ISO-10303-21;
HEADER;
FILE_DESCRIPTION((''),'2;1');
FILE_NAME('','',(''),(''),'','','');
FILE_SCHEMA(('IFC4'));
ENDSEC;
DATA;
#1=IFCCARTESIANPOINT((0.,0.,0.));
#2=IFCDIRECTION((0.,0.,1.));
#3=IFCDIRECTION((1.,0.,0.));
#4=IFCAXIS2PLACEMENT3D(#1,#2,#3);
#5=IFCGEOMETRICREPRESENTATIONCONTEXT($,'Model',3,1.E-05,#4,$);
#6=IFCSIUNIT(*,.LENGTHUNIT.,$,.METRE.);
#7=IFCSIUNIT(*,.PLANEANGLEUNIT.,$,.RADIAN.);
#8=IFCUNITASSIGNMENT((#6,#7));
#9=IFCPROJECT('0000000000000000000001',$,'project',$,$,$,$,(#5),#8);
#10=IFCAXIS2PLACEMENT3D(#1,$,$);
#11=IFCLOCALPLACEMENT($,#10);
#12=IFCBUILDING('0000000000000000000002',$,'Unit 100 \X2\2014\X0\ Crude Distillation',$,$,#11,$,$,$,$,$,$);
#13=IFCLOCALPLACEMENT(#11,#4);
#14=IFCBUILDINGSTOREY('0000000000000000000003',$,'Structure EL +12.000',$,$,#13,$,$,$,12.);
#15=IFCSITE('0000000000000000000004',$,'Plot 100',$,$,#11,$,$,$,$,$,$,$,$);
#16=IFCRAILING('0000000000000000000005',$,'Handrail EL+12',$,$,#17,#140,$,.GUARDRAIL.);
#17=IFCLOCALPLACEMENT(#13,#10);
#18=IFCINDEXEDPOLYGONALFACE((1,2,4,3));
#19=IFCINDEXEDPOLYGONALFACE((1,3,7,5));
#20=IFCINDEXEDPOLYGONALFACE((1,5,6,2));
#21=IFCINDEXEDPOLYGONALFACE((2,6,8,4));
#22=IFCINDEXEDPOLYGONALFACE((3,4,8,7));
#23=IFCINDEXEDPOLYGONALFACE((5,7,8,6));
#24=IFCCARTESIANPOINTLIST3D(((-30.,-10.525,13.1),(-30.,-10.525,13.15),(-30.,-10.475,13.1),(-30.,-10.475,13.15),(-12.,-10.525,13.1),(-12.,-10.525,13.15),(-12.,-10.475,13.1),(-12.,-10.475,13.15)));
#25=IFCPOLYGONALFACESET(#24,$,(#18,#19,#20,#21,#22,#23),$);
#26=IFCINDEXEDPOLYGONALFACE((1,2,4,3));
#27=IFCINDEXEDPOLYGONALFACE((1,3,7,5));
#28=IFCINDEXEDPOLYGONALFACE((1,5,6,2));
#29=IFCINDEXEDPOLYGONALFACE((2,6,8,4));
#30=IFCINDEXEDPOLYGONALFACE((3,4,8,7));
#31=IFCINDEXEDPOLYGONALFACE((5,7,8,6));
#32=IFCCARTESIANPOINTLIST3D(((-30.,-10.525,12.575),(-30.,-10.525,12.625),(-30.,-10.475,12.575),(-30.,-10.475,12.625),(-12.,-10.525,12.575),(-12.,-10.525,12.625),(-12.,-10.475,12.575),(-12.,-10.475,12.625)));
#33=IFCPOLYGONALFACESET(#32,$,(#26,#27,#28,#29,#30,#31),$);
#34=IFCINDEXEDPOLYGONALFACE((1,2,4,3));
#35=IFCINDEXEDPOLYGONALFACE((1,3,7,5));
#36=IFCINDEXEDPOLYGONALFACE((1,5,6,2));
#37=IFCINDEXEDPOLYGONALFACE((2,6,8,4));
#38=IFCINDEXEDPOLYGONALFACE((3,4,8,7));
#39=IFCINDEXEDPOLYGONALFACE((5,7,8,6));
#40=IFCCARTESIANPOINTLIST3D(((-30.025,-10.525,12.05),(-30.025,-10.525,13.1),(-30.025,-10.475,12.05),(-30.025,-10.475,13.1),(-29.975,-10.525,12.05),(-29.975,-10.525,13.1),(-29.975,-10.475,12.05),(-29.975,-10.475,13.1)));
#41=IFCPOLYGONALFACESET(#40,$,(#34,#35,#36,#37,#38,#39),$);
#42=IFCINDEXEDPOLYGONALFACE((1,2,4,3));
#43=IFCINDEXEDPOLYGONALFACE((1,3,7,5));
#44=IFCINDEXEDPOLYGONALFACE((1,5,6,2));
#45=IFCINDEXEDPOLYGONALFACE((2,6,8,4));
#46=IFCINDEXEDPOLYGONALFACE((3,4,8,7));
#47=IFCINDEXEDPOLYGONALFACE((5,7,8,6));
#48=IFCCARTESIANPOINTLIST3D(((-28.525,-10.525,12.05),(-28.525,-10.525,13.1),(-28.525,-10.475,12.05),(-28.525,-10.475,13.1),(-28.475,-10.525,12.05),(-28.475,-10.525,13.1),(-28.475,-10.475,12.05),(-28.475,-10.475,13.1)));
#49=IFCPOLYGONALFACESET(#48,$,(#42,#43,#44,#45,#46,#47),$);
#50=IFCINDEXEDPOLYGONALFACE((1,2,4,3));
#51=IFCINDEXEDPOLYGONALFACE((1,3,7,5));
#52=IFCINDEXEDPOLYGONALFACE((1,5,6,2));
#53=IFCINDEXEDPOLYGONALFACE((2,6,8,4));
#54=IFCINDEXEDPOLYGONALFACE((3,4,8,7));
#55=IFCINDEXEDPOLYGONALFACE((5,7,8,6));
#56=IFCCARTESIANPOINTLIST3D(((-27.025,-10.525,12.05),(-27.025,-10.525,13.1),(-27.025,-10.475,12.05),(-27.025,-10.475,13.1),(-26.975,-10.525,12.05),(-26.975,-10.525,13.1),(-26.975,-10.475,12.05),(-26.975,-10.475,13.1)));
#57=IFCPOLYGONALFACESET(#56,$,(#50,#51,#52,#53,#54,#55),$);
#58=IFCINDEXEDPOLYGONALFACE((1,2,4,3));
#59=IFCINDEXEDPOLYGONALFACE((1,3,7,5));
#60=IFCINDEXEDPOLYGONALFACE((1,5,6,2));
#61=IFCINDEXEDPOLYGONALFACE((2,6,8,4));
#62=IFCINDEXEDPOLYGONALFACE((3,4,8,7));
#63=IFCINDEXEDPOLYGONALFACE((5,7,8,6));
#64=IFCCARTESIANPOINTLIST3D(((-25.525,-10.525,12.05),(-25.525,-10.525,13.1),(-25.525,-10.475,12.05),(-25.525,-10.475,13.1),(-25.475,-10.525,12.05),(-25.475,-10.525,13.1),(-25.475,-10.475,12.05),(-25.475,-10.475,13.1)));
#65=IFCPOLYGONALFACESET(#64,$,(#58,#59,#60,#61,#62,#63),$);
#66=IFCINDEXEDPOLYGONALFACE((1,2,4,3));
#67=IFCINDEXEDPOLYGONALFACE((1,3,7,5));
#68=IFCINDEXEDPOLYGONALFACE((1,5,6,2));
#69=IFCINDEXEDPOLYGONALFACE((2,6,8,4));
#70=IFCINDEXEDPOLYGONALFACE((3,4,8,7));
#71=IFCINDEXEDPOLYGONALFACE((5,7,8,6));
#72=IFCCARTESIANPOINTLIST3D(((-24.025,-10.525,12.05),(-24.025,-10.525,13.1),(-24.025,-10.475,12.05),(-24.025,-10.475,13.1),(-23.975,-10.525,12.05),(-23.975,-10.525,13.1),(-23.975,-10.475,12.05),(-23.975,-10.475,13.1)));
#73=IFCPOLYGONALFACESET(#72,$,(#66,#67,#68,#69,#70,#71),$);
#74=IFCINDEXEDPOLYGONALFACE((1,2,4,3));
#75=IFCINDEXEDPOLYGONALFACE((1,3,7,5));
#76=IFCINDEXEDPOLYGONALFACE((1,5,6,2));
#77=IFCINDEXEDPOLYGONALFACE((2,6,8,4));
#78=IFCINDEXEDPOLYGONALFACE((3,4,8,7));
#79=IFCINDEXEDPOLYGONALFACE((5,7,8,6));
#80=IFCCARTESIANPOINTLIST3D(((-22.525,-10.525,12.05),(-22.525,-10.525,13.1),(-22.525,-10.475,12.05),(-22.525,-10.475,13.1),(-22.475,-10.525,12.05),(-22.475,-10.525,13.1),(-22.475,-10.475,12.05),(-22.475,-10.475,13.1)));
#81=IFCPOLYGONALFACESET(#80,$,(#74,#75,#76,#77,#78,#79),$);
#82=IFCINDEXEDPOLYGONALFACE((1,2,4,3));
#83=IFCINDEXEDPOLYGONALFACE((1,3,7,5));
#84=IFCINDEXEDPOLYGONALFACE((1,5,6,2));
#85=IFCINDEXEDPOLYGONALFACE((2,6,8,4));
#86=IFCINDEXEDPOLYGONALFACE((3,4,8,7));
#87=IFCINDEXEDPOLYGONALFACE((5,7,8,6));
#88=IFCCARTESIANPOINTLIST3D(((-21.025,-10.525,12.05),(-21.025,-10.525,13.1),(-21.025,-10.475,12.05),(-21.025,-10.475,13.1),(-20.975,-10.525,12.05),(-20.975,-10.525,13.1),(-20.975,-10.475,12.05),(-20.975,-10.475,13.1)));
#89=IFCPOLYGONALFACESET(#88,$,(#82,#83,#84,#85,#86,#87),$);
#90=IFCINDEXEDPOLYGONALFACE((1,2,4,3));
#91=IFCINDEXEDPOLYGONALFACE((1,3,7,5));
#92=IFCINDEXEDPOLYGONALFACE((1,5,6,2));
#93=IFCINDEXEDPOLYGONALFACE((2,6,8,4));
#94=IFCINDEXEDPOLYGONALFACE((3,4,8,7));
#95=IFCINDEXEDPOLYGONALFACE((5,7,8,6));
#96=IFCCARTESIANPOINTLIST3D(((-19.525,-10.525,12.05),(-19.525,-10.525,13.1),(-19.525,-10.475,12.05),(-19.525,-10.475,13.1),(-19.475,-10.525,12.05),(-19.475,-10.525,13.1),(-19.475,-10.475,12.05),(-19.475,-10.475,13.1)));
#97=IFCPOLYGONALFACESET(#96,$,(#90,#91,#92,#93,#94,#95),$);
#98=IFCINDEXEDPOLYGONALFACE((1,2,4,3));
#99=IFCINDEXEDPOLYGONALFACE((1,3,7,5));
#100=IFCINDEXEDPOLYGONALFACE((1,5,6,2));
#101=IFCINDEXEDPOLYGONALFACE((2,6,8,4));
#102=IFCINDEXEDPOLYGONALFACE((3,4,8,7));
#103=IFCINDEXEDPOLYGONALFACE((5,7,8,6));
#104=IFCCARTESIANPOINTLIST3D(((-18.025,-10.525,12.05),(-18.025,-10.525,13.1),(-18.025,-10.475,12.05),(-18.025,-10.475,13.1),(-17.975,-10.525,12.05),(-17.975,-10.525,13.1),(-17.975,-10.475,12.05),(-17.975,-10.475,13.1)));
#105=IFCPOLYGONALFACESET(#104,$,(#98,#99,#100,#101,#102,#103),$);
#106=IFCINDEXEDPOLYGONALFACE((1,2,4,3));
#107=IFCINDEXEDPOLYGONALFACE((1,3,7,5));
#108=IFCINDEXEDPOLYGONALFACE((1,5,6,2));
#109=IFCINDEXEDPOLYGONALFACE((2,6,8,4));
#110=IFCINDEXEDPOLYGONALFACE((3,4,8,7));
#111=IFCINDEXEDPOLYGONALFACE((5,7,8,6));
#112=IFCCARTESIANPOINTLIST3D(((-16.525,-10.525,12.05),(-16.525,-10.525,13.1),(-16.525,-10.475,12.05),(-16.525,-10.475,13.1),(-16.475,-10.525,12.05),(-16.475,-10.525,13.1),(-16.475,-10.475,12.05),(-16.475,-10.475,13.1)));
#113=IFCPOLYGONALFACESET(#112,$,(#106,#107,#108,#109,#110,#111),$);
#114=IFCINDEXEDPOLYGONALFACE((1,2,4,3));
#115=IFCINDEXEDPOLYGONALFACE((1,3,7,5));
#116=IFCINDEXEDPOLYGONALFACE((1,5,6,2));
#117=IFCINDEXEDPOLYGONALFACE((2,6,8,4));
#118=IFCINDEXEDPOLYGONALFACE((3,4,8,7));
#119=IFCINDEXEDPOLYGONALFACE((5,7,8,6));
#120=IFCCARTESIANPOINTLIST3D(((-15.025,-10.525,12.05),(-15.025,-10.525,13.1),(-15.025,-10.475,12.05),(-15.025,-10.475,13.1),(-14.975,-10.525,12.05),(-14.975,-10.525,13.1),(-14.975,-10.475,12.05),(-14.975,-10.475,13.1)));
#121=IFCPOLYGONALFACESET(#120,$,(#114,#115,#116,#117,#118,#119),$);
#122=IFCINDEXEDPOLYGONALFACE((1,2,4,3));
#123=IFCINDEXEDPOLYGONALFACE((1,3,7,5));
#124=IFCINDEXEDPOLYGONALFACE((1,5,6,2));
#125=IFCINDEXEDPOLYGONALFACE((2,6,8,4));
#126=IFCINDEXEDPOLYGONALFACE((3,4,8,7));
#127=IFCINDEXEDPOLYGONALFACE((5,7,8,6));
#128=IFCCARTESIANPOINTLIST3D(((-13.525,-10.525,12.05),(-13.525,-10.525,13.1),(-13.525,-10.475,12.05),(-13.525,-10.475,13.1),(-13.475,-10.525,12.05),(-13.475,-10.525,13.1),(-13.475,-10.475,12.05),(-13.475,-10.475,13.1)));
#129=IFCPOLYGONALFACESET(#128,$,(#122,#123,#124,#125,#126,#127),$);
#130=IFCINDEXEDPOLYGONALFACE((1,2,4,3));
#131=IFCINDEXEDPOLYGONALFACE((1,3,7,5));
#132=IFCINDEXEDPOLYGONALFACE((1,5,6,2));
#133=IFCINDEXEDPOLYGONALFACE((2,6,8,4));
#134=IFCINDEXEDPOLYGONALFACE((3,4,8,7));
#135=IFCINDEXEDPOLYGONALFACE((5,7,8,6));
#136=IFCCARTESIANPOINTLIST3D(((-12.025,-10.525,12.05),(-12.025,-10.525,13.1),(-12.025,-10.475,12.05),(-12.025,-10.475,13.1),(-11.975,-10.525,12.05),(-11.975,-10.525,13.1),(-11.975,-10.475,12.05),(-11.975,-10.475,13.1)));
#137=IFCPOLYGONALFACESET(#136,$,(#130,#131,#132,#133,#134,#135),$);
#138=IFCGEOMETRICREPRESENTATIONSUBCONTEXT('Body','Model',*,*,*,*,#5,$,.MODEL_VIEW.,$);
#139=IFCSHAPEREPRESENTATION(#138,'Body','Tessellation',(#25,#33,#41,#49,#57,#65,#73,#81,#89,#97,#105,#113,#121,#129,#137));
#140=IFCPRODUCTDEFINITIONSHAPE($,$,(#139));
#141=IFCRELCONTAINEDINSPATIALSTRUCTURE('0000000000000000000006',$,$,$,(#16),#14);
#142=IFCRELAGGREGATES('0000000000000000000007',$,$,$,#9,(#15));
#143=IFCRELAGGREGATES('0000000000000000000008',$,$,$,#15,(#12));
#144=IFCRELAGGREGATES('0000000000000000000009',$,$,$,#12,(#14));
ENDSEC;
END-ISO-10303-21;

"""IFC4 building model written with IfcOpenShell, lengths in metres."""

from ifc_helpers import new_model, si_unit, frame, origin, origin_with_axes, origin_2d, place, context, subcontext, project, spatial, rectangle, extrude, element, save


model = new_model("IFC4")

# Units and contexts
model_context = context("Model", 3, precision=1e-05, world=origin_with_axes())
body_context = subcontext(model_context, "Body", "Model", "MODEL_VIEW")
ifc_project = project(units=[si_unit("LENGTHUNIT", "METRE"), si_unit("PLANEANGLEUNIT", "RADIAN")], contexts=[model_context])

# Site, building, storey
placement = place(None, origin())
site = spatial("IfcSite", under=ifc_project, at=placement, Name="Plot 100")
building = spatial("IfcBuilding", under=site, at=placement, Name="Unit 100 — Crude Distillation")
storey_placement = place(placement, origin_with_axes())
storey = spatial("IfcBuildingStorey", under=building, at=storey_placement, Name="Structure EL +12.000", Elevation=12.0)

# Railing
railing_1_placement = place(storey_placement, origin_with_axes())
element("IfcRailing", 1, at=railing_1_placement, inside=storey, Name="Handrail EL+12", PredefinedType="GUARDRAIL", context=body_context, shape_type="SweptSolid", body=[
    extrude(rectangle(XDim=0.05, YDim=0.05, at=origin_2d()), frame((-30.0, -10.5, 13.125), z_axis=(1.0, 0.0, 0.0), x_axis=(0.0, 1.0, 0.0)), (0.0, 0.0, 1.0), 18.0),
    extrude(rectangle(XDim=0.05, YDim=0.05, at=origin_2d()), frame((-30.0, -10.5, 12.6), z_axis=(1.0, 0.0, 0.0), x_axis=(0.0, 1.0, 0.0)), (0.0, 0.0, 1.0), 18.0),
    extrude(rectangle(XDim=0.05, YDim=0.05, at=origin_2d()), frame((-30.0, -10.5, 12.05), z_axis=(0.0, 0.0, 1.0), x_axis=(1.0, 0.0, 0.0)), (0.0, 0.0, 1.0), 1.05),
    extrude(rectangle(XDim=0.05, YDim=0.05, at=origin_2d()), frame((-28.5, -10.5, 12.05), z_axis=(0.0, 0.0, 1.0), x_axis=(1.0, 0.0, 0.0)), (0.0, 0.0, 1.0), 1.05),
    extrude(rectangle(XDim=0.05, YDim=0.05, at=origin_2d()), frame((-27.0, -10.5, 12.05), z_axis=(0.0, 0.0, 1.0), x_axis=(1.0, 0.0, 0.0)), (0.0, 0.0, 1.0), 1.05),
    extrude(rectangle(XDim=0.05, YDim=0.05, at=origin_2d()), frame((-25.5, -10.5, 12.05), z_axis=(0.0, 0.0, 1.0), x_axis=(1.0, 0.0, 0.0)), (0.0, 0.0, 1.0), 1.05),
    extrude(rectangle(XDim=0.05, YDim=0.05, at=origin_2d()), frame((-24.0, -10.5, 12.05), z_axis=(0.0, 0.0, 1.0), x_axis=(1.0, 0.0, 0.0)), (0.0, 0.0, 1.0), 1.05),
    extrude(rectangle(XDim=0.05, YDim=0.05, at=origin_2d()), frame((-22.5, -10.5, 12.05), z_axis=(0.0, 0.0, 1.0), x_axis=(1.0, 0.0, 0.0)), (0.0, 0.0, 1.0), 1.05),
    extrude(rectangle(XDim=0.05, YDim=0.05, at=origin_2d()), frame((-21.0, -10.5, 12.05), z_axis=(0.0, 0.0, 1.0), x_axis=(1.0, 0.0, 0.0)), (0.0, 0.0, 1.0), 1.05),
    extrude(rectangle(XDim=0.05, YDim=0.05, at=origin_2d()), frame((-19.5, -10.5, 12.05), z_axis=(0.0, 0.0, 1.0), x_axis=(1.0, 0.0, 0.0)), (0.0, 0.0, 1.0), 1.05),
    extrude(rectangle(XDim=0.05, YDim=0.05, at=origin_2d()), frame((-18.0, -10.5, 12.05), z_axis=(0.0, 0.0, 1.0), x_axis=(1.0, 0.0, 0.0)), (0.0, 0.0, 1.0), 1.05),
    extrude(rectangle(XDim=0.05, YDim=0.05, at=origin_2d()), frame((-16.5, -10.5, 12.05), z_axis=(0.0, 0.0, 1.0), x_axis=(1.0, 0.0, 0.0)), (0.0, 0.0, 1.0), 1.05),
    extrude(rectangle(XDim=0.05, YDim=0.05, at=origin_2d()), frame((-15.0, -10.5, 12.05), z_axis=(0.0, 0.0, 1.0), x_axis=(1.0, 0.0, 0.0)), (0.0, 0.0, 1.0), 1.05),
    extrude(rectangle(XDim=0.05, YDim=0.05, at=origin_2d()), frame((-13.5, -10.5, 12.05), z_axis=(0.0, 0.0, 1.0), x_axis=(1.0, 0.0, 0.0)), (0.0, 0.0, 1.0), 1.05),
    extrude(rectangle(XDim=0.05, YDim=0.05, at=origin_2d()), frame((-12.0, -10.5, 12.05), z_axis=(0.0, 0.0, 1.0), x_axis=(1.0, 0.0, 0.0)), (0.0, 0.0, 1.0), 1.05),
])

save(model, "model.ifc")
